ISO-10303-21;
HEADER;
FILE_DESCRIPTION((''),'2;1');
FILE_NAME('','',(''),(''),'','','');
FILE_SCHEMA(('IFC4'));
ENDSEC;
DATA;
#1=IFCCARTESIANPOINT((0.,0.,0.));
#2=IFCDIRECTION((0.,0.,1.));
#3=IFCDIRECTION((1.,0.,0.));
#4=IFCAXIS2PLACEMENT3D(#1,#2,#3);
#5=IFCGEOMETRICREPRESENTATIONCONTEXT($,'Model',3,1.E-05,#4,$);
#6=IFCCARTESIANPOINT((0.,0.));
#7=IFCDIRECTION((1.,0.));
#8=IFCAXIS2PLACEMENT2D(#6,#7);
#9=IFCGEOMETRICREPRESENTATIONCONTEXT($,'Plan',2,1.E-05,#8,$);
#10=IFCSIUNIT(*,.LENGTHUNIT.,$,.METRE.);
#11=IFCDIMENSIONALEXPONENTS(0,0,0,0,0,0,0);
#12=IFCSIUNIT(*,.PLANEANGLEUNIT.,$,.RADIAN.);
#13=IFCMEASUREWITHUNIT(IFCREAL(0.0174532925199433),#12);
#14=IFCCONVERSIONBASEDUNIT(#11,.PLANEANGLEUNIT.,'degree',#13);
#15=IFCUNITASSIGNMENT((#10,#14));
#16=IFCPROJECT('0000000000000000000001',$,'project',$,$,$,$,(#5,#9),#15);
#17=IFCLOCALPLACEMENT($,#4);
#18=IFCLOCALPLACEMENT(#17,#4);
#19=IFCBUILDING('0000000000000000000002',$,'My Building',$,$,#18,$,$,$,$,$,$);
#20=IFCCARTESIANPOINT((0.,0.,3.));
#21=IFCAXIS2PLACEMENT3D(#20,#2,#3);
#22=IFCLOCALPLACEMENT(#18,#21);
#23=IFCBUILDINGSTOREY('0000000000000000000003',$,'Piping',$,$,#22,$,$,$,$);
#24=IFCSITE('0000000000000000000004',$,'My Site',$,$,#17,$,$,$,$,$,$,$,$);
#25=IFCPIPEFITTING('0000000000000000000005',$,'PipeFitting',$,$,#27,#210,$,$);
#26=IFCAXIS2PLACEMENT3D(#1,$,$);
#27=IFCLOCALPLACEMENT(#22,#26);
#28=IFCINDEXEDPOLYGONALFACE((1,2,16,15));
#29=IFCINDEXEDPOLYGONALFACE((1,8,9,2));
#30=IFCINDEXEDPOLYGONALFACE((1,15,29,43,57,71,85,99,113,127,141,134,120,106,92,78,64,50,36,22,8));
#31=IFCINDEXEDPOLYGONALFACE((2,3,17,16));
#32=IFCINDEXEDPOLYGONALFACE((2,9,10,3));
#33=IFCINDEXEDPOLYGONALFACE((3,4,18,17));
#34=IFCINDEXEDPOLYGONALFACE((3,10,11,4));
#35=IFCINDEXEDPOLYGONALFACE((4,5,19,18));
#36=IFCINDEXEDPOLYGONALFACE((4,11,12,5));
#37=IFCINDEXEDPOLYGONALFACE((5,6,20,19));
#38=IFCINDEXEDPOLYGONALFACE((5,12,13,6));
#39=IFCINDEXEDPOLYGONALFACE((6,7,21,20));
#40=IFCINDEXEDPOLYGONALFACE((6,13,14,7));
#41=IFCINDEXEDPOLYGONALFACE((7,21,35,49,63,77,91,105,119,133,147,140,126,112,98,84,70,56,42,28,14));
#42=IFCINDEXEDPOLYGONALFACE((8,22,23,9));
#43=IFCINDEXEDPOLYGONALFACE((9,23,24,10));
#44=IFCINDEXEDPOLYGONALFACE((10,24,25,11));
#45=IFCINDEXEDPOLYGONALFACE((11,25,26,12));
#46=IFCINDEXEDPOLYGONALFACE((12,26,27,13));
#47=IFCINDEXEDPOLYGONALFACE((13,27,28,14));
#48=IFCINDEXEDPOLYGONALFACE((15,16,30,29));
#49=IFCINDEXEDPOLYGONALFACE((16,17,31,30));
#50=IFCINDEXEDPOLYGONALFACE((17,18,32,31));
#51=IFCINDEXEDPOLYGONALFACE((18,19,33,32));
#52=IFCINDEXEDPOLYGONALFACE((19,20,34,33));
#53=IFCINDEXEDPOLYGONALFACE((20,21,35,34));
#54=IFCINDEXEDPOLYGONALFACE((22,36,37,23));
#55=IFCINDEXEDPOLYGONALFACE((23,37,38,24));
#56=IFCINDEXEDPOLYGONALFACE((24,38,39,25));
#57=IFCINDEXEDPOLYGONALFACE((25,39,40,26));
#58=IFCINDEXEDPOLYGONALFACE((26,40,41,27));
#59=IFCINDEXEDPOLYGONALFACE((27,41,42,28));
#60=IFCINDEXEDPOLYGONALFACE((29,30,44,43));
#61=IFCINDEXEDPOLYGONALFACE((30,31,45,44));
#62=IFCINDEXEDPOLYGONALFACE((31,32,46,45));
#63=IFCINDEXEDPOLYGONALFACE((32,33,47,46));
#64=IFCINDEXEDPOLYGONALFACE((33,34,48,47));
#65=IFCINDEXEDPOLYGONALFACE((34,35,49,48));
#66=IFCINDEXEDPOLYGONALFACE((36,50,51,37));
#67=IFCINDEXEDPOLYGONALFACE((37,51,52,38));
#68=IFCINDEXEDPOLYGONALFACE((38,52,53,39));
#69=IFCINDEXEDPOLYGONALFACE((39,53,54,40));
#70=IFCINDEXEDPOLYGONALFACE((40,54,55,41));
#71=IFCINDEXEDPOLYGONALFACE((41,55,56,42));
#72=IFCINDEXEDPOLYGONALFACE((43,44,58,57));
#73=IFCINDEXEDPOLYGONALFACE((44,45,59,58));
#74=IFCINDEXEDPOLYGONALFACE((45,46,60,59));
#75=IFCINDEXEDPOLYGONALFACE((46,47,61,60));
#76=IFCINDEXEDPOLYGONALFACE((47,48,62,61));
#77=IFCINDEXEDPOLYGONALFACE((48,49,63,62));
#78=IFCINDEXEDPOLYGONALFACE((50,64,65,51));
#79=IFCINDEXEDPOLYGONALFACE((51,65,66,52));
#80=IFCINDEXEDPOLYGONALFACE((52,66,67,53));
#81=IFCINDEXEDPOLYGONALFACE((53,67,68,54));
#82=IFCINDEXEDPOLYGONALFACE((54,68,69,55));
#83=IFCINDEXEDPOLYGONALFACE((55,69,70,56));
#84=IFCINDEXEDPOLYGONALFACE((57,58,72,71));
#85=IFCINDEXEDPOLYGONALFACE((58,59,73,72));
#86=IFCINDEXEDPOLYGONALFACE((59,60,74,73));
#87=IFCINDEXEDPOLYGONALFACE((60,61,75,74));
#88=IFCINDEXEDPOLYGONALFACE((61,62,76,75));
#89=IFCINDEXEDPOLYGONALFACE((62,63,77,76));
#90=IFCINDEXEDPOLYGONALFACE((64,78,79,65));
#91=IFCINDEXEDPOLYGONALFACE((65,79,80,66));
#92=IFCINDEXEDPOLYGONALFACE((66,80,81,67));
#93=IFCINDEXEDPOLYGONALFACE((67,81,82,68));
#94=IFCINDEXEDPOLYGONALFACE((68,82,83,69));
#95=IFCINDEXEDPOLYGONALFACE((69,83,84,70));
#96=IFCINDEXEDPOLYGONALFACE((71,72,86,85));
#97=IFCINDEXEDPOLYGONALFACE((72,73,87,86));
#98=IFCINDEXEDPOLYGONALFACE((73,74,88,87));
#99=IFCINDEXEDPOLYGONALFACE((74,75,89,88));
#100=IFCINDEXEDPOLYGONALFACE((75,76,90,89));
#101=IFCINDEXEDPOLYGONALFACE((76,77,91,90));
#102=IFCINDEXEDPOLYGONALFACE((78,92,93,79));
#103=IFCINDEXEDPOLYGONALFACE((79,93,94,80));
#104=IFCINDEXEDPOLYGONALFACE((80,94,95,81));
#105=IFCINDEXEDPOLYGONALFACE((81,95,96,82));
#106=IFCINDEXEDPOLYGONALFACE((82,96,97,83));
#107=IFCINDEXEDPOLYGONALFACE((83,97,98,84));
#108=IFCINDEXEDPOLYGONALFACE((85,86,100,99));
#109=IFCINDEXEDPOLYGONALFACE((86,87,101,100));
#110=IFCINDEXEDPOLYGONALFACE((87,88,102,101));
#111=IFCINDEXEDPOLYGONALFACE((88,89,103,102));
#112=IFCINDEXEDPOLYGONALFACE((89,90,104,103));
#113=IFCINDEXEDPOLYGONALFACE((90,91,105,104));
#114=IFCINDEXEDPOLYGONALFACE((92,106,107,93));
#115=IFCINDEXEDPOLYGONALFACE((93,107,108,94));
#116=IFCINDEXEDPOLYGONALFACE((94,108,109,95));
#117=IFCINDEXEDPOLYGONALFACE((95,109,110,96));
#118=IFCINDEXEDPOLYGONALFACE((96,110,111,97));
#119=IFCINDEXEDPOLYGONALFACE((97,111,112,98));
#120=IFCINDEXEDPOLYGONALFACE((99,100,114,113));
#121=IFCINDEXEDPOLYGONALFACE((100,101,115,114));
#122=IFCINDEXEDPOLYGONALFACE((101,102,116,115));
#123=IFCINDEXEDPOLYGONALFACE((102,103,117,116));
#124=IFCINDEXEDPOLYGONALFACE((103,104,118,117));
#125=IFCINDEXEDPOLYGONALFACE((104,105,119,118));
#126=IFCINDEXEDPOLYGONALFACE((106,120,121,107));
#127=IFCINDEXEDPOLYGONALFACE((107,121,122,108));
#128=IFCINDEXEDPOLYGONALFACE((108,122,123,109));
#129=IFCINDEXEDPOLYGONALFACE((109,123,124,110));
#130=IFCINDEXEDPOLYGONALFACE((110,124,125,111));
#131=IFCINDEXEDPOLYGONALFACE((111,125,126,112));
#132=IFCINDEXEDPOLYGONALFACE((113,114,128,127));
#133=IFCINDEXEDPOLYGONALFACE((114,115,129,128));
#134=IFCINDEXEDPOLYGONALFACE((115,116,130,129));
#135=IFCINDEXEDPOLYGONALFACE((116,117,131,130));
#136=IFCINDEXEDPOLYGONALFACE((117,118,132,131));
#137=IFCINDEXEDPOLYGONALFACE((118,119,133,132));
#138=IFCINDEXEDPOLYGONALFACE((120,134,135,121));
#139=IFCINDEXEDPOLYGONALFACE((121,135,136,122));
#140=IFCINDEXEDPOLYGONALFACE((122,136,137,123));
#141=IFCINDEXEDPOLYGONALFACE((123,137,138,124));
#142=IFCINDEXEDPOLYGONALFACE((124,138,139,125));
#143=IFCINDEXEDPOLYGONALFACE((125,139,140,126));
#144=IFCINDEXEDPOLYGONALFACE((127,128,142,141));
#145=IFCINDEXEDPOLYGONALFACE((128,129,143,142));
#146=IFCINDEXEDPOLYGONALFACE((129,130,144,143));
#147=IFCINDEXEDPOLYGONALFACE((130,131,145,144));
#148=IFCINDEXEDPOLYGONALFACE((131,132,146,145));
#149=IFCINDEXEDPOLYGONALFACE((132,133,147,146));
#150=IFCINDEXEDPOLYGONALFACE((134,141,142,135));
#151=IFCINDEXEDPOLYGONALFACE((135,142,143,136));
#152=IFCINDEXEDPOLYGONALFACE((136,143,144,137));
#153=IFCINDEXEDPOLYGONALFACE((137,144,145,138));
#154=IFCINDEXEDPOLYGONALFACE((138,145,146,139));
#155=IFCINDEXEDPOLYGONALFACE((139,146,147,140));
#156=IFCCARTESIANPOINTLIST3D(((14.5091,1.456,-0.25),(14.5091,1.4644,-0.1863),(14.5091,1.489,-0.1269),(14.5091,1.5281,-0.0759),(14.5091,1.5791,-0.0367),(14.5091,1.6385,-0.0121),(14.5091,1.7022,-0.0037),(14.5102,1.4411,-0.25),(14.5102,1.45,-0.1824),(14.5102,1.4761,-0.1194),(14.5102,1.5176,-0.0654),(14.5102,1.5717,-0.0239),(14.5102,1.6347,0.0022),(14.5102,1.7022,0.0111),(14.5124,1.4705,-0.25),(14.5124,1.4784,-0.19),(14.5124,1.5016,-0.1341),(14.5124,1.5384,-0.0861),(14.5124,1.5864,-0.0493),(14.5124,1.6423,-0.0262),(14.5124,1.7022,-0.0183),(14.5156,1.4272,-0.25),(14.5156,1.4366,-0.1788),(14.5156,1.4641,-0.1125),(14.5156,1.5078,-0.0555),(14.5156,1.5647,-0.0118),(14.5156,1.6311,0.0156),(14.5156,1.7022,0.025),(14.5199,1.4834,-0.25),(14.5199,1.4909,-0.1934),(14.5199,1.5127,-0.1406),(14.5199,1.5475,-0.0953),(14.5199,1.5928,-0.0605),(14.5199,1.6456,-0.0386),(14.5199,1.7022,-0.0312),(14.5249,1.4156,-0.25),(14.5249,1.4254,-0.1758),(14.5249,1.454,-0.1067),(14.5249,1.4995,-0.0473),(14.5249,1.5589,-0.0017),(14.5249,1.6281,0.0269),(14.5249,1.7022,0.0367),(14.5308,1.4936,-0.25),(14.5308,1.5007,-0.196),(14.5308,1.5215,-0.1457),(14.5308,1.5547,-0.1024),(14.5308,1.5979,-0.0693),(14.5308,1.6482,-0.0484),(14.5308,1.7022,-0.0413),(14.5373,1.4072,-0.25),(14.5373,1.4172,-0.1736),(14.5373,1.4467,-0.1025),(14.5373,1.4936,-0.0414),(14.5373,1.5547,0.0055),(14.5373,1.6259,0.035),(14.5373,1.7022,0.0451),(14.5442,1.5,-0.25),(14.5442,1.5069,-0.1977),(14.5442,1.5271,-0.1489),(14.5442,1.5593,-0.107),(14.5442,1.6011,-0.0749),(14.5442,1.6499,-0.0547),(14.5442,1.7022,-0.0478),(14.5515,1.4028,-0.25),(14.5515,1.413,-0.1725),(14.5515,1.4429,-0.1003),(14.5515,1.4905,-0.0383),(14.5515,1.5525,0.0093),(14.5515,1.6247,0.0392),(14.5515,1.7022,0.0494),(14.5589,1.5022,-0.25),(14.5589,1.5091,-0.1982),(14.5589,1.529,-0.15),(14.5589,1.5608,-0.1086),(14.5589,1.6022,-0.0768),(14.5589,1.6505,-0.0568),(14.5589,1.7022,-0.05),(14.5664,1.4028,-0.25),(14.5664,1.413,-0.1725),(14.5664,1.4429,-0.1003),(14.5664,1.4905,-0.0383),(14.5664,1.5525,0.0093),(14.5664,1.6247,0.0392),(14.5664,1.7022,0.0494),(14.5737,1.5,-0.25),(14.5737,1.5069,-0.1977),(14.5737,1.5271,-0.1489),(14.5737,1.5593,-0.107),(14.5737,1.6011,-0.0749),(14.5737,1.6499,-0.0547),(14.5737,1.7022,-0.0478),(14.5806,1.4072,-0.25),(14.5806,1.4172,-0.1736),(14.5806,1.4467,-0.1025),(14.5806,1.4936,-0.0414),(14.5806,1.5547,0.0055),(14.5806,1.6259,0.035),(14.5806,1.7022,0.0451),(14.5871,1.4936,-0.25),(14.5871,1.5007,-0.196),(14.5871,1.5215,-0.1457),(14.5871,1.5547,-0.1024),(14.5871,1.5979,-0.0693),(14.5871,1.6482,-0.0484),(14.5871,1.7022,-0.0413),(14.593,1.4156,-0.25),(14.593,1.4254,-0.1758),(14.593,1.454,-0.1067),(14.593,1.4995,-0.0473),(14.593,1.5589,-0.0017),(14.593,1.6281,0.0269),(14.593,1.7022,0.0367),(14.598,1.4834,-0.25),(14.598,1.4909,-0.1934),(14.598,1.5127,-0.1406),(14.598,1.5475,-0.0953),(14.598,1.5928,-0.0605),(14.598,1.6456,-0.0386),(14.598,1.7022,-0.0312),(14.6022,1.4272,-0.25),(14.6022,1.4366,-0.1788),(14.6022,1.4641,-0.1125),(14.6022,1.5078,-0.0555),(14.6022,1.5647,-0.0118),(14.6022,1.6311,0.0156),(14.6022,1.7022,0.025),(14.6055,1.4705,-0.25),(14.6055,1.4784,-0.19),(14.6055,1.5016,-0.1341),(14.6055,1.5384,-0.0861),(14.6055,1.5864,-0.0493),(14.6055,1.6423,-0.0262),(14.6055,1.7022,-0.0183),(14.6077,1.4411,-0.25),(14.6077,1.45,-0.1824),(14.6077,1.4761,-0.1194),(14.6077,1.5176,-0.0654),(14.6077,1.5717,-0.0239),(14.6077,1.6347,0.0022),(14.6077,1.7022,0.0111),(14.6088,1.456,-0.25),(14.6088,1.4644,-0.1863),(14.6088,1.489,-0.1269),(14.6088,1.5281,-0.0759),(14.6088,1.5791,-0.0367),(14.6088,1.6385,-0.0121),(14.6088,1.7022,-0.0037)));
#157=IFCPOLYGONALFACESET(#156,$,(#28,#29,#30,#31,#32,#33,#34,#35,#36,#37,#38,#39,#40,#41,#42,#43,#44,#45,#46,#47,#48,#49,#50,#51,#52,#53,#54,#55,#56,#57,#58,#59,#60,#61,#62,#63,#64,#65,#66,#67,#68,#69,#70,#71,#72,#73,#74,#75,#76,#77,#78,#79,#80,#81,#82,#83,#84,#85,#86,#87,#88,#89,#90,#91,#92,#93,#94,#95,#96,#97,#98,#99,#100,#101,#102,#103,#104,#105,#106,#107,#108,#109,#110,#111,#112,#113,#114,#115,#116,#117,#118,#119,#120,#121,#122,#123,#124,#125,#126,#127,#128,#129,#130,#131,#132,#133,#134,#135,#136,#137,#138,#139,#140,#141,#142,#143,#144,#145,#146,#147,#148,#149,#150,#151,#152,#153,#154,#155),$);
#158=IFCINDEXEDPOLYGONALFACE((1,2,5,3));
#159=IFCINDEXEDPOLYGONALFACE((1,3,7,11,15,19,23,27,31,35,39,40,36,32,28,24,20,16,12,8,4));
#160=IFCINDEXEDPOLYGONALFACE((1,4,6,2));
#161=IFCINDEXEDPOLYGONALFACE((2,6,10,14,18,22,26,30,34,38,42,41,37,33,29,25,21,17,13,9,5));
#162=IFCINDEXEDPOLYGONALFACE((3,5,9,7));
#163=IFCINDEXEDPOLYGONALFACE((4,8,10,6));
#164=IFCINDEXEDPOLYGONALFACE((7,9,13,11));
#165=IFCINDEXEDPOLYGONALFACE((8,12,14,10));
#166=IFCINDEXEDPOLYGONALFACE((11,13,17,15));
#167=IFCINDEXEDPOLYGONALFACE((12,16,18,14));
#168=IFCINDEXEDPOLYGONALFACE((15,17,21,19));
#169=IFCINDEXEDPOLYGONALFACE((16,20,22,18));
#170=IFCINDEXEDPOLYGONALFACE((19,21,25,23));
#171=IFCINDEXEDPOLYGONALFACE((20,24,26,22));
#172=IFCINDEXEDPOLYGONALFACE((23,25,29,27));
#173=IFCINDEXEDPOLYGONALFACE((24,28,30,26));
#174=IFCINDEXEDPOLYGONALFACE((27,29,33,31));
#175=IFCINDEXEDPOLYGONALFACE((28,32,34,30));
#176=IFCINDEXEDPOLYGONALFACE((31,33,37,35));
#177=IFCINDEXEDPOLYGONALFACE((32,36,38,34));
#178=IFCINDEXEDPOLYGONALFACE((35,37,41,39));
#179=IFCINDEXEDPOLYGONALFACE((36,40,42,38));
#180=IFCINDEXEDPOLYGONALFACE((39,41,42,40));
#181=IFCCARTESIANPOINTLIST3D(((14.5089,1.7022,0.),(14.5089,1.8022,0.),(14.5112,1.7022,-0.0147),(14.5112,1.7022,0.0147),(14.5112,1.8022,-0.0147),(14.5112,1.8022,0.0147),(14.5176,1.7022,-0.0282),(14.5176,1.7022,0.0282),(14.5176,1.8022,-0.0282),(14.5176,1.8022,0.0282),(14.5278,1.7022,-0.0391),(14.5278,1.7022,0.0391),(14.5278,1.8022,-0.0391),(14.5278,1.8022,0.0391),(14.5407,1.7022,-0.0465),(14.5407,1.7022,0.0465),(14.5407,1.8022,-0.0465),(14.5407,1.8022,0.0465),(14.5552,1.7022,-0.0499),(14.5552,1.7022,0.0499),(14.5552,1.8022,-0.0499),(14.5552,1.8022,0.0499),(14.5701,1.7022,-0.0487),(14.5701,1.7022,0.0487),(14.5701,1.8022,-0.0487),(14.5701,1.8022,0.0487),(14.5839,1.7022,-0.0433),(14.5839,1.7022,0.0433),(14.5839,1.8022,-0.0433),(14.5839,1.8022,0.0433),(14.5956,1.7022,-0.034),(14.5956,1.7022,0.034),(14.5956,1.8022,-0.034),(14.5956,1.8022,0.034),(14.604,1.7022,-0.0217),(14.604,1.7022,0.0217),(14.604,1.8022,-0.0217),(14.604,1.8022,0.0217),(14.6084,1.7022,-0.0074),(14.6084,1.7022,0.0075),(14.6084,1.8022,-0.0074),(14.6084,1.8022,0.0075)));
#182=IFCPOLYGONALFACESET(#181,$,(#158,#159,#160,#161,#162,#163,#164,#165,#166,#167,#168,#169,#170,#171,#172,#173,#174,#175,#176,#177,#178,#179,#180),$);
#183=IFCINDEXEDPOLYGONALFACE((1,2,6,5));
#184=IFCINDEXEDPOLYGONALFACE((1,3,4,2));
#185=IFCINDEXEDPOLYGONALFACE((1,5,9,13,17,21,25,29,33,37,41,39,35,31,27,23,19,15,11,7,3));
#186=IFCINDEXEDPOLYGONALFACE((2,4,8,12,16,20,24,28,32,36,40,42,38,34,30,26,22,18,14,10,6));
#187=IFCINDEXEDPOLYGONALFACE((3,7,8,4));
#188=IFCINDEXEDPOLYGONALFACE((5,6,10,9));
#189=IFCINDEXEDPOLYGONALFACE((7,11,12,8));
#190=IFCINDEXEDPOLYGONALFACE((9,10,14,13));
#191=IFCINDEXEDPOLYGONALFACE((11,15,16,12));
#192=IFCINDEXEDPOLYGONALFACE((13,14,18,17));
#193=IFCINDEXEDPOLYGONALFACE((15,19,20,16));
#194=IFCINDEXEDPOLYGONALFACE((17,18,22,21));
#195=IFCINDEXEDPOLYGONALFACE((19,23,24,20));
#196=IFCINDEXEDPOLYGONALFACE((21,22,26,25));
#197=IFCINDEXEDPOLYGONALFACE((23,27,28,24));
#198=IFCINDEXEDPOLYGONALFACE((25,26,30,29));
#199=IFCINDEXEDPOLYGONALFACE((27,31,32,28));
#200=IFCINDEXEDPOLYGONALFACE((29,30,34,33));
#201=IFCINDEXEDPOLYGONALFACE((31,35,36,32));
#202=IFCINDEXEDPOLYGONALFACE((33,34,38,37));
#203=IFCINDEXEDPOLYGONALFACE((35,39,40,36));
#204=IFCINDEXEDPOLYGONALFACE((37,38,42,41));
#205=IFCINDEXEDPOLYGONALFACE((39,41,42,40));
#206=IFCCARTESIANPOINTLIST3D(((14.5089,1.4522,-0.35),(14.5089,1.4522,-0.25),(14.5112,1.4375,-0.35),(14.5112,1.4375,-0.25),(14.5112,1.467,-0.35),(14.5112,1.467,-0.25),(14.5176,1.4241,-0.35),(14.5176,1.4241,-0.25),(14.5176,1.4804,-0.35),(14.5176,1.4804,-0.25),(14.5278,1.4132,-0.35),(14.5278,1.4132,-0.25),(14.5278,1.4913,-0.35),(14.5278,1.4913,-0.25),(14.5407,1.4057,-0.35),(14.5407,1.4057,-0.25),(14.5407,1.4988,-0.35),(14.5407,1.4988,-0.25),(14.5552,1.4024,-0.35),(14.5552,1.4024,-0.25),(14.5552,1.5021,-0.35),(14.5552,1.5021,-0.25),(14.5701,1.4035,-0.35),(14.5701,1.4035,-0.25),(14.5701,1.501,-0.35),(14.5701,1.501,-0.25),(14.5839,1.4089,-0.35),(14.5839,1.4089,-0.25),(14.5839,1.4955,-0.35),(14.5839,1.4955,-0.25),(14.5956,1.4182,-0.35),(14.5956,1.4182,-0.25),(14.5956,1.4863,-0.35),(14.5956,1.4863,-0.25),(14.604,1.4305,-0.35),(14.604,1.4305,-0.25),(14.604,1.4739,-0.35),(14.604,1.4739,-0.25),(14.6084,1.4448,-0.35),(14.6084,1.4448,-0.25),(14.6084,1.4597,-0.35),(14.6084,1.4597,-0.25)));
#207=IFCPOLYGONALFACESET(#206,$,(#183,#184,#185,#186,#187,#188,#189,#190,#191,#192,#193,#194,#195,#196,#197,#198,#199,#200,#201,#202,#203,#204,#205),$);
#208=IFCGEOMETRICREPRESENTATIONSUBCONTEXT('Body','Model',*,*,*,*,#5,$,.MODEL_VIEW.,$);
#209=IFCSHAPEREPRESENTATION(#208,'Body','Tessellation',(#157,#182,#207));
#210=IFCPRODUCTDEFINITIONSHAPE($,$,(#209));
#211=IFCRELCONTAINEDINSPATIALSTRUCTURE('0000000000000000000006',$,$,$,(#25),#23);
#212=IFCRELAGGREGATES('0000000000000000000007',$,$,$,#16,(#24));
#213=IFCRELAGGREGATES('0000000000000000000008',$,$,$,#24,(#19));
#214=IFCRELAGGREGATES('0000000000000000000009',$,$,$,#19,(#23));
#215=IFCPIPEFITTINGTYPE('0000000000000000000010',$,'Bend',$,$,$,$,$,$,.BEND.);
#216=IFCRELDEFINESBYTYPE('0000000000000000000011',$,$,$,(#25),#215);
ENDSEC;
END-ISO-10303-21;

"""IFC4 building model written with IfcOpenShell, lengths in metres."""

from ifc_helpers import new_model, entity, si_unit, converted_unit, frame, origin_with_axes, origin_2d_with_axis, place, context, subcontext, project, spatial, circle, extrude, source, transform, mapped, type_object, type_shapes, element, save


model = new_model("IFC4")

# Units and contexts
model_context = context("Model", 3, precision=1e-05, world=origin_with_axes())
plan_context = context("Plan", 2, precision=1e-05, world=origin_2d_with_axis())
body_context = subcontext(model_context, "Body", "Model", "MODEL_VIEW")
ifc_project = project(units=[si_unit("LENGTHUNIT", "METRE"), converted_unit("PLANEANGLEUNIT", "degree", entity("IfcReal", 0.0174532925199433), si_unit("PLANEANGLEUNIT", "RADIAN"), dimensions=[0, 0, 0, 0, 0, 0, 0])], contexts=[model_context, plan_context])

# Site, building, storey
site_placement = place(None, origin_with_axes())
site = spatial("IfcSite", under=ifc_project, at=site_placement, Name="My Site")
building_placement = place(site_placement, origin_with_axes())
building = spatial("IfcBuilding", under=site, at=building_placement, Name="My Building")
storey_placement = place(building_placement, frame((0.0, 0.0, 3.0), z_axis=(0.0, 0.0, 1.0), x_axis=(1.0, 0.0, 0.0)))
storey = spatial("IfcBuildingStorey", under=building, at=storey_placement, Name="Piping")

# Pipe fitting
pipe_fitting_type = type_object("IfcPipeFittingType", Name="Bend", PredefinedType="BEND")
shared_shape = source(origin_with_axes(), body_context, "Body", "SolidModel", [
    entity("IfcSweptDiskSolid", entity("IfcIndexedPolyCurve", entity("IfcCartesianPointList3D", [[0.0, 0.0, -0.1], [0.0, -0.0732, -0.2768], [0.0, -0.25, -0.35]]), [entity("IfcArcIndex", [1, 2, 3])]), 0.05),
    extrude(circle(Radius=0.05), origin_with_axes(), (0.0, 0.0, -1.0), 0.1),
    extrude(circle(Radius=0.05), frame((0.0, -0.25, -0.35), z_axis=(0.0, -1.0, 0.0), x_axis=(1.0, 0.0, 0.0)), (0.0, 0.0, 1.0), 0.1),
])
type_shapes(pipe_fitting_type, [shared_shape])
for number, where, z_axis, x_axis, name in (
    (1, (14.5589, 1.8022, 0.0), (0.0, 1.0, 0.0), (-1.0, 0.0, 0.0), "PipeFitting"),
):
    element("IfcPipeFitting", number, at=place(storey_placement, frame(where, z_axis=z_axis, x_axis=x_axis)), inside=storey, type_object=pipe_fitting_type, Name=name, context=body_context, shape_type="MappedRepresentation", body=[
        mapped(shared_shape, transform((0.0, 0.0, 0.0), x_axis=(1.0, 0.0, 0.0), y_axis=(0.0, 1.0, 0.0), z_axis=(0.0, 0.0, 1.0), scale=1.0)),
    ])

save(model, "model.ifc")
